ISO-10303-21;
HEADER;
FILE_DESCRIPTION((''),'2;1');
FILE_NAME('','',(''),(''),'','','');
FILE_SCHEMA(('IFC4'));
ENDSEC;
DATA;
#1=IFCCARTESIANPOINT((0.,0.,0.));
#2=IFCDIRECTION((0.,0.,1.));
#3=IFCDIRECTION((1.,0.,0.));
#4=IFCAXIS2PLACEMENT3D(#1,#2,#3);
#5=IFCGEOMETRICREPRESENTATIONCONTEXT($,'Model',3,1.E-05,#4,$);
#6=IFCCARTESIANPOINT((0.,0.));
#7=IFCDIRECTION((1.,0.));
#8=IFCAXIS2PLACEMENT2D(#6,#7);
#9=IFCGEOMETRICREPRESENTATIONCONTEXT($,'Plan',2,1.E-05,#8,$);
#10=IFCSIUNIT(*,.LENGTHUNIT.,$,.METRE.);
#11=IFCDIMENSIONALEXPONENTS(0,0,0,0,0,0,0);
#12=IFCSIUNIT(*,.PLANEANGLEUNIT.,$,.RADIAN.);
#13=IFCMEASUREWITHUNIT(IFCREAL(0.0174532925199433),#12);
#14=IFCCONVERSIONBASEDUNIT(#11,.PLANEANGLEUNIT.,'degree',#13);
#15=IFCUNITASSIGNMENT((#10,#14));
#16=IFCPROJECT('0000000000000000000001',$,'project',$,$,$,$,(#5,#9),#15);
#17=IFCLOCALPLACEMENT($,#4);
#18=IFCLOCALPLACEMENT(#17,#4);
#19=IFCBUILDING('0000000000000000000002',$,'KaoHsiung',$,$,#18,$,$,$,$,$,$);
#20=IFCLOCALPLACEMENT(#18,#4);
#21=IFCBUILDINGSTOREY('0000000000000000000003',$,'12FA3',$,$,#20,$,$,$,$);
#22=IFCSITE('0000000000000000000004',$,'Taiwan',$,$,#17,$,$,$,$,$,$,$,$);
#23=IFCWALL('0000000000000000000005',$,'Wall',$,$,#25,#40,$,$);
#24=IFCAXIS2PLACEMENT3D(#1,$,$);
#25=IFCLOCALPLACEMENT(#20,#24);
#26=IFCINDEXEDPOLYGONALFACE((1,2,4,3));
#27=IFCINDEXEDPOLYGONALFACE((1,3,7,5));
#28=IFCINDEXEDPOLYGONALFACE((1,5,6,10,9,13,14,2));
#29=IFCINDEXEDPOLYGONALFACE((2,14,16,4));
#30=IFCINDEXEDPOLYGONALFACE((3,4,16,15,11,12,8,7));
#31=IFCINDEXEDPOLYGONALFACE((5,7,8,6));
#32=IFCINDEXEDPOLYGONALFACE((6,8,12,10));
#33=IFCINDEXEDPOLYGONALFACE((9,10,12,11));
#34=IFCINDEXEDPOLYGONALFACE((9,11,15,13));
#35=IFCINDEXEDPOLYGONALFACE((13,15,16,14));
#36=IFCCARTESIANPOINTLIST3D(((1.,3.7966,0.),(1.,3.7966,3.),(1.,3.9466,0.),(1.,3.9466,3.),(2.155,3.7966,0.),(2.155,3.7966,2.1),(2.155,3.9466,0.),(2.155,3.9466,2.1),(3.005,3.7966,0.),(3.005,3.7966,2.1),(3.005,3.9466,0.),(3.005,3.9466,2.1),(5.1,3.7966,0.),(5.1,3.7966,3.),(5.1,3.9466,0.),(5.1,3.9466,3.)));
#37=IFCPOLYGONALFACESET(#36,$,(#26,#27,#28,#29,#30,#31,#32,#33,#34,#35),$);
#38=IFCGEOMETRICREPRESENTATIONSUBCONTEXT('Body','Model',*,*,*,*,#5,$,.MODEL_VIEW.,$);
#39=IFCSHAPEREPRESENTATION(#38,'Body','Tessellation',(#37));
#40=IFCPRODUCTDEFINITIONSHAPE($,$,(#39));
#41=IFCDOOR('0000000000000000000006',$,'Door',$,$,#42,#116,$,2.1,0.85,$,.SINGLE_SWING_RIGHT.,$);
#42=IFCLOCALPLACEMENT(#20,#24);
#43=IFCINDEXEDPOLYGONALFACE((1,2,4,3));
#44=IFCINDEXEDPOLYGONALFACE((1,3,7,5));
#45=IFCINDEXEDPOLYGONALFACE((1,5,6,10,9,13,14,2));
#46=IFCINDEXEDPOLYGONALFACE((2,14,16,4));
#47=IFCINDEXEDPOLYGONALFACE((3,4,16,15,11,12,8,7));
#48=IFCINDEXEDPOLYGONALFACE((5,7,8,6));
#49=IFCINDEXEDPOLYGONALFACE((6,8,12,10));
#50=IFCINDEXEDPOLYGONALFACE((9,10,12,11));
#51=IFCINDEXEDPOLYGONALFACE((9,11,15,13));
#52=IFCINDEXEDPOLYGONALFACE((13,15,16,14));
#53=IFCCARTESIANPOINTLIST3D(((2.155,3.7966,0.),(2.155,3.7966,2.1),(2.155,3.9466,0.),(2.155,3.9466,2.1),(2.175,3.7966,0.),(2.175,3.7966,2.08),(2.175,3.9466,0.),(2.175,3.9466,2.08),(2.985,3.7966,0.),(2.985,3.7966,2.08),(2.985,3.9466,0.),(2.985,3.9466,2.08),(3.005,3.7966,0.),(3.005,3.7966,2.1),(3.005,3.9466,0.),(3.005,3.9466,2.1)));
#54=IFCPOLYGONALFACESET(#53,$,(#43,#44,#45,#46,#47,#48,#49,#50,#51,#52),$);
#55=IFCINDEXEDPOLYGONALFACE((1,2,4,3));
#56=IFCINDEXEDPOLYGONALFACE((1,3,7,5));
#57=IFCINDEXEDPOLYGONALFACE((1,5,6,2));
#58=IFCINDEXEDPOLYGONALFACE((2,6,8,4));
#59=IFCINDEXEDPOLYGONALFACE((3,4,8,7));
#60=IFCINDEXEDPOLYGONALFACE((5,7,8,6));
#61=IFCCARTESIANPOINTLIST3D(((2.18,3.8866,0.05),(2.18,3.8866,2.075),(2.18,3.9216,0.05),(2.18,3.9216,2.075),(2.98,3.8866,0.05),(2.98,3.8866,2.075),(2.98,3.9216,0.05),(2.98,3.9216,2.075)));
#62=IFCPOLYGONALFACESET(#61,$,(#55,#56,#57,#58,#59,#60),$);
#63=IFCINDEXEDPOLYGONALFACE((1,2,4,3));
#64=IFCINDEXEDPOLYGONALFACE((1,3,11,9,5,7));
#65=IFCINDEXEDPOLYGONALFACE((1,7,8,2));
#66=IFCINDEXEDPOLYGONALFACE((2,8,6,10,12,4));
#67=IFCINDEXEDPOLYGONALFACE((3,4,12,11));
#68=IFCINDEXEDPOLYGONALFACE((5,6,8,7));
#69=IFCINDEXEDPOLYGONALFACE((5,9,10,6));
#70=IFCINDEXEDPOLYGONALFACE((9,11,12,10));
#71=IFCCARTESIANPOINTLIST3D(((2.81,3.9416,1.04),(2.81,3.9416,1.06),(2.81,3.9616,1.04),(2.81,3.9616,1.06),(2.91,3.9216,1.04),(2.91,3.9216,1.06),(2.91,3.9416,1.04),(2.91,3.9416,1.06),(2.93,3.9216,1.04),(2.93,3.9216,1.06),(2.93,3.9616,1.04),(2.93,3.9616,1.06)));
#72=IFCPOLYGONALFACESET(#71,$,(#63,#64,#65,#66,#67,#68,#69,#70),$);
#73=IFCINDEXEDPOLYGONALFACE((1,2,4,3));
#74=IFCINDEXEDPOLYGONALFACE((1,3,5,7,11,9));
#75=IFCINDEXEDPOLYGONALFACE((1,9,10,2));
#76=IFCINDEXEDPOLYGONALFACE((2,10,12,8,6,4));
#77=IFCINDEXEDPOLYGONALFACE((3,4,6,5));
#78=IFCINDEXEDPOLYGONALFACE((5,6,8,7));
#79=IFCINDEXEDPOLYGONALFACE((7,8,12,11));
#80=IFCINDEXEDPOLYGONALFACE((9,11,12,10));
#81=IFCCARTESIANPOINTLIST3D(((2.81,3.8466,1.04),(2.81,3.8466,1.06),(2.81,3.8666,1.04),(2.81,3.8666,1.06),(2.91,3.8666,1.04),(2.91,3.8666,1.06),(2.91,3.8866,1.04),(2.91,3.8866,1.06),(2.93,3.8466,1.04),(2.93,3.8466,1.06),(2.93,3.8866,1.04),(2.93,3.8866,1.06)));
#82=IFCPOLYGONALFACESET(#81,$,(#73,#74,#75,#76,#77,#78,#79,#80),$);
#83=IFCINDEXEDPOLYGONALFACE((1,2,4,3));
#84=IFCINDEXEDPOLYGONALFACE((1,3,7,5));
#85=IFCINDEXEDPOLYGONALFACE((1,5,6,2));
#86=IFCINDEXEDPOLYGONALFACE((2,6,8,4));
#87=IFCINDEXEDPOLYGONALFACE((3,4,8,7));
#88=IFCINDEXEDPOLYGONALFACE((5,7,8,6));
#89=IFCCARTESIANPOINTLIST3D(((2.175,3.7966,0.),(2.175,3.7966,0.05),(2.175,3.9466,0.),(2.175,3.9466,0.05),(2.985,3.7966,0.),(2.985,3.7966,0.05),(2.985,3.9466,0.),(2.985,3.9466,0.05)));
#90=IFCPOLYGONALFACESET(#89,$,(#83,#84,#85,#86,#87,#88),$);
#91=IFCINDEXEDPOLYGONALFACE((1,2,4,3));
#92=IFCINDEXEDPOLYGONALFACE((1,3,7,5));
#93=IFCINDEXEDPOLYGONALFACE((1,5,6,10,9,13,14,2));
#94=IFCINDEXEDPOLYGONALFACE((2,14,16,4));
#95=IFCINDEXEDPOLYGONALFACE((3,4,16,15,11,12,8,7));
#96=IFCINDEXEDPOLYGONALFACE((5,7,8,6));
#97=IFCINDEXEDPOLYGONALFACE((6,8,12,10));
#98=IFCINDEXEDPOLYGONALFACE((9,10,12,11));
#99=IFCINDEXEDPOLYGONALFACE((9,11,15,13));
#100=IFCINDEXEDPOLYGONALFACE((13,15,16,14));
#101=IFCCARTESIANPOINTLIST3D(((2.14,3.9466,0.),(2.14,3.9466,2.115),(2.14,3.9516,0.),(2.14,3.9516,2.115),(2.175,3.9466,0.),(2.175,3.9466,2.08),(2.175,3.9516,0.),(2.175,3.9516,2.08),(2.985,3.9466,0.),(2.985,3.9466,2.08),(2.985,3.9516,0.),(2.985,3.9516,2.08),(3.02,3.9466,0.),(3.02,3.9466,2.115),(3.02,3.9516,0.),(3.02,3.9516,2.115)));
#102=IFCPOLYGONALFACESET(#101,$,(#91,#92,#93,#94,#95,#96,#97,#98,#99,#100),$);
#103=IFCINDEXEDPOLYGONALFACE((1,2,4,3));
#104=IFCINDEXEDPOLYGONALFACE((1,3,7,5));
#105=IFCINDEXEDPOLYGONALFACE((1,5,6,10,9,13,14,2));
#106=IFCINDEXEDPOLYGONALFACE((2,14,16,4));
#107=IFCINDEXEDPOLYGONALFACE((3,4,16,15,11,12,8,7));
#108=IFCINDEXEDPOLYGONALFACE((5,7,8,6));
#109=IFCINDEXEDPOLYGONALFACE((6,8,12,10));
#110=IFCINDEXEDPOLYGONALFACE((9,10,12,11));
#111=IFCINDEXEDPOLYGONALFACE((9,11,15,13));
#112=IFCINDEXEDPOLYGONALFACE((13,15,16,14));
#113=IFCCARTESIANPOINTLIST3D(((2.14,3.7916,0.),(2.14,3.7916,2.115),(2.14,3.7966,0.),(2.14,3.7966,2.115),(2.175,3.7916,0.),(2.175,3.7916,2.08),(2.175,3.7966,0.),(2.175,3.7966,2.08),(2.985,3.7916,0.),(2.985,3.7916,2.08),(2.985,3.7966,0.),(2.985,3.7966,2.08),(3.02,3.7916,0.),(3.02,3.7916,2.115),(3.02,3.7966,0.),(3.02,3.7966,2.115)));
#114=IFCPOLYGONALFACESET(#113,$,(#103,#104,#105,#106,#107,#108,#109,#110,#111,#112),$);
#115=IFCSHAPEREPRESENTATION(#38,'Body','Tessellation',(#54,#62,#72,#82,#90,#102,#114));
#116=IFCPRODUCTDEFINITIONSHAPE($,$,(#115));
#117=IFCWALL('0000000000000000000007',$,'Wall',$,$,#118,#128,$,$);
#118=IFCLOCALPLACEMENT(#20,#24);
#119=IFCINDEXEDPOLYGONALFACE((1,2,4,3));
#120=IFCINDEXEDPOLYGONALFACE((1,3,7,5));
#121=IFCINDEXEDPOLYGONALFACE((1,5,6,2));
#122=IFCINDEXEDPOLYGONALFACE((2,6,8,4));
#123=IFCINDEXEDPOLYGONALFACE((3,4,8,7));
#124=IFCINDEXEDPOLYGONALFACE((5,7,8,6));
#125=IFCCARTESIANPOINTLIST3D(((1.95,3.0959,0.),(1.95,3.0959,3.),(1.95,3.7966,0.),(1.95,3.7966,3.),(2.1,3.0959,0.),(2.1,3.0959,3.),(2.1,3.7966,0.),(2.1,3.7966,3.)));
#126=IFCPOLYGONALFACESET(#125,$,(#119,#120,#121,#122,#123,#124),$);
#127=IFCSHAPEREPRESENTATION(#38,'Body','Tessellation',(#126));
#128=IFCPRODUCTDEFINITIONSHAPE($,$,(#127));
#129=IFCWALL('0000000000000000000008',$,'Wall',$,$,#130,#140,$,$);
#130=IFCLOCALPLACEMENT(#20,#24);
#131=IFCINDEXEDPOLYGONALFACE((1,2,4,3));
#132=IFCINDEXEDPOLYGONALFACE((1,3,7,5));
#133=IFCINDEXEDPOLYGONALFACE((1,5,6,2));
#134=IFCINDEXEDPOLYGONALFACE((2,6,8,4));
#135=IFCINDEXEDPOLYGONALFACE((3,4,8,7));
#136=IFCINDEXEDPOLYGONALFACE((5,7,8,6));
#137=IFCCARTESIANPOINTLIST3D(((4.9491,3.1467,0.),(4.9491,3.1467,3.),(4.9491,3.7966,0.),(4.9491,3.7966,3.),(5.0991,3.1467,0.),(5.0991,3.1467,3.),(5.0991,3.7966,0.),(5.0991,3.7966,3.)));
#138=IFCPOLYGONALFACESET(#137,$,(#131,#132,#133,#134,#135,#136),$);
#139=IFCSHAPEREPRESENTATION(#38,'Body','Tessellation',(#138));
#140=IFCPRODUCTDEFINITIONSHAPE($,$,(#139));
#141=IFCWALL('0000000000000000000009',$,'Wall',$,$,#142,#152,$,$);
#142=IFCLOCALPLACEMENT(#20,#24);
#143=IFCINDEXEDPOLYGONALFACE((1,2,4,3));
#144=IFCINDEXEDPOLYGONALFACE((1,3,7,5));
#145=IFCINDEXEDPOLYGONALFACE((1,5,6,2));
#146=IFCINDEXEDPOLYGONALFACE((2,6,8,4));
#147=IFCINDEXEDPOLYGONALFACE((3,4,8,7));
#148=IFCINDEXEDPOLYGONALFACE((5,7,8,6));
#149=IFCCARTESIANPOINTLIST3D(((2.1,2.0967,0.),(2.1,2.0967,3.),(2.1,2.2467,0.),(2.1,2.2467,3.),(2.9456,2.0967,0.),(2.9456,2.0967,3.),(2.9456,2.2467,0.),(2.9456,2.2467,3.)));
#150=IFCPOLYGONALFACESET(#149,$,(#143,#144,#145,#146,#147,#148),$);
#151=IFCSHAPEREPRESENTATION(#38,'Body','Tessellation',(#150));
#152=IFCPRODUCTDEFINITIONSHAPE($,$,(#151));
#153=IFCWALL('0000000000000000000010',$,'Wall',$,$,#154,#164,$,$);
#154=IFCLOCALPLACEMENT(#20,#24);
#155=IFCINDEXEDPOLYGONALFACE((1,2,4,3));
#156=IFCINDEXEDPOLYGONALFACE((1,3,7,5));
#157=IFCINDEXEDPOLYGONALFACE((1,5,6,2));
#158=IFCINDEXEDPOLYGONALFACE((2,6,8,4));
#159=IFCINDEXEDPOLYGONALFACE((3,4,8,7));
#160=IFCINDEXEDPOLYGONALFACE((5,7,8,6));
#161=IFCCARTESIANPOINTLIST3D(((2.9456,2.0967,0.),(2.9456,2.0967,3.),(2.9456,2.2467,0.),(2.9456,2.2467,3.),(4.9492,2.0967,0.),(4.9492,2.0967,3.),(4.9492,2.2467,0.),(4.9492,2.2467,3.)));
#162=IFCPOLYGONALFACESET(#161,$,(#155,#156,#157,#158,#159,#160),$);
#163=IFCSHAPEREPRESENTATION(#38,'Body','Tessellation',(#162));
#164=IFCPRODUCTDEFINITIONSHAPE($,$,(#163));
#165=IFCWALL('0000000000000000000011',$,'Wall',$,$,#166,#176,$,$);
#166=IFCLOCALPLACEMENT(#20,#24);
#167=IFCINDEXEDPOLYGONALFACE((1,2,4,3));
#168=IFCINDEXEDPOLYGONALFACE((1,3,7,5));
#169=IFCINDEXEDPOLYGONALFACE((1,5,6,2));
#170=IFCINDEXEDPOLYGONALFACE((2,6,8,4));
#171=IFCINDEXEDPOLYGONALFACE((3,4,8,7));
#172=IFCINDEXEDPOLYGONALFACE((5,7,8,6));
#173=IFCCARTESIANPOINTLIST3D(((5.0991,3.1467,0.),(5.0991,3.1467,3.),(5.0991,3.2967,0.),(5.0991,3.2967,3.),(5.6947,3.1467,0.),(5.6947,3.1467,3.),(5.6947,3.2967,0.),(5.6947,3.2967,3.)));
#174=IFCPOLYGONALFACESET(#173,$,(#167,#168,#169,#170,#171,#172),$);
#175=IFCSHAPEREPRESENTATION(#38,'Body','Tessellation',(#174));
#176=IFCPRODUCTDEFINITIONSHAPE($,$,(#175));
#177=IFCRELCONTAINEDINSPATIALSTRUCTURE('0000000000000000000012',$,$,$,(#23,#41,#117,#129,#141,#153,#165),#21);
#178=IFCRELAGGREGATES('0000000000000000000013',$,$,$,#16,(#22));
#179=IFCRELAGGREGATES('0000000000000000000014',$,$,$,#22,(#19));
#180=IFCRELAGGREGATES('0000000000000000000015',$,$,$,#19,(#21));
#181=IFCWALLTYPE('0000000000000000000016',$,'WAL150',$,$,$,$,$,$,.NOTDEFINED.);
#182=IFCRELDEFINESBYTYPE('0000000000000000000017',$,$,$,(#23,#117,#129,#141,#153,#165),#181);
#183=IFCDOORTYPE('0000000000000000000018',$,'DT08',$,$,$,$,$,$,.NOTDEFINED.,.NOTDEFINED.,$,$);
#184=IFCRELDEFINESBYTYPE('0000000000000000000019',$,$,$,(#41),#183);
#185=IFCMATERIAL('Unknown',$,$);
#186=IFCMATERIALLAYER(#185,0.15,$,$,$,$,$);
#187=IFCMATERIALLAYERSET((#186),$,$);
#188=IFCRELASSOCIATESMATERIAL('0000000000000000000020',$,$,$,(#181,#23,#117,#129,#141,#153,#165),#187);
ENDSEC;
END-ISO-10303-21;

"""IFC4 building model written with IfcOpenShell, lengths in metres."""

from ifc_helpers import new_model, entity, si_unit, converted_unit, frame, origin_with_axes, origin_2d_with_axis, place, context, subcontext, project, spatial, line, indexed_curve, outline, extrude, shape, source, transform, mapped, material, layer, layer_set, layer_usage, type_object, type_shapes, element, fill, save


model = new_model("IFC4")

# Units and contexts
model_context = context("Model", 3, precision=1e-05, world=origin_with_axes())
plan_context = context("Plan", 2, precision=1e-05, world=origin_2d_with_axis())
body_context_1 = subcontext(model_context, "Body", "Model", "MODEL_VIEW")
body_context_2 = subcontext(plan_context, "Body", "Plan", "PLAN_VIEW")
ifc_project = project(units=[si_unit("LENGTHUNIT", "METRE"), converted_unit("PLANEANGLEUNIT", "degree", entity("IfcReal", 0.0174532925199433), si_unit("PLANEANGLEUNIT", "RADIAN"), dimensions=[0, 0, 0, 0, 0, 0, 0])], contexts=[model_context, plan_context])

# Site, building, storey
site_placement = place(None, origin_with_axes())
site = spatial("IfcSite", under=ifc_project, at=site_placement, Name="Taiwan")
building_placement = place(site_placement, origin_with_axes())
building = spatial("IfcBuilding", under=site, at=building_placement, Name="KaoHsiung")
storey_placement = place(building_placement, origin_with_axes())
storey = spatial("IfcBuildingStorey", under=building, at=storey_placement, Name="12FA3")

# Shared definitions
ifc_material = material(Name="Unknown")

# Wall, opening, door
ifc_layer_1 = layer(ifc_material, 0.15)
ifc_layer_set_1 = layer_set([ifc_layer_1])
ifc_layer_usage_1 = layer_usage(ifc_layer_set_1, "AXIS2", "POSITIVE", 0.0)
wall_type_1 = type_object("IfcWallType", Name="WAL150", PredefinedType="NOTDEFINED", material=ifc_layer_set_1)
wall_1_placement = place(storey_placement, frame((1.0, 3.7966, 0.0), z_axis=(0.0, 0.0, 1.0), x_axis=(1.0, 0.0, 0.0)))
wall_1 = element("IfcWall", 1, at=wall_1_placement, inside=storey, type_object=wall_type_1, material=ifc_layer_usage_1, Name="Wall", context=body_context_1, shape_type="SweptSolid", body=[
    extrude(outline(indexed_curve([(0.0, 0.0), (0.0, 0.15), (4.1, 0.15), (4.1, 0.0)], segments=[line(1, 2, 3, 4, 1)])), origin_with_axes(), (0.0, 0.0, 1.0), 3.0),
])
shared_shape_1 = source(origin_with_axes(), body_context_1, "Body", "SweptSolid", [
    extrude(outline(indexed_curve([(0.0, 0.0), (0.85, 0.0), (0.85, 2.1), (0.0, 2.1)], segments=[line(1, 2, 3, 4, 1)])), frame((0.0, -0.6, 0.0), z_axis=(0.0, -1.0, 0.0), x_axis=(1.0, 0.0, 0.0)), (0.0, 0.0, -1.0), 1.2),
])
opening_1_placement = place(wall_1_placement, frame((2.005, 0.15, 0.0), z_axis=(0.0, 0.0, 1.0), x_axis=(-1.0, 0.0, 0.0)))
opening_1 = element("IfcOpeningElement", 2, at=opening_1_placement, cuts=wall_1, PredefinedType="OPENING", context=body_context_1, shape_type="MappedRepresentation", body=[
    mapped(shared_shape_1, transform((0.0, 0.0, 0.0), x_axis=(1.0, 0.0, 0.0), y_axis=(0.0, 1.0, 0.0), z_axis=(0.0, 0.0, 1.0), scale=1.0)),
])
door_type_1 = type_object("IfcDoorType", Name="DT08", OperationType="NOTDEFINED", PredefinedType="NOTDEFINED")
shared_shape_2 = source(origin_with_axes(), body_context_1, "Body", "SweptSolid", [
    extrude(outline(indexed_curve([(0.0, 0.0), (0.0, 2.1), (0.85, 2.1), (0.85, 0.0), (0.83, 0.0), (0.83, 2.08), (0.02, 2.08), (0.02, 0.0)], segments=[line(1, 2, 3, 4, 5, 6, 7, 8, 1)])), frame((0.0, 0.0, 0.0), z_axis=(0.0, -1.0, 0.0), x_axis=(1.0, 0.0, 0.0)), (0.0, 0.0, -1.0), 0.15),
    extrude(outline(indexed_curve([(0.0, 0.0), (0.8, 0.0), (0.8, 0.035), (0.0, 0.035)], segments=[line(1, 2, 3, 4, 1)])), frame((0.025, 0.025, 0.05), z_axis=(0.0, 0.0, 1.0), x_axis=(1.0, 0.0, 0.0)), (0.0, 0.0, 1.0), 2.025),
    extrude(outline(indexed_curve([(0.0, 0.0), (0.0, -0.04), (0.12, -0.04), (0.12, -0.02), (0.02, -0.02), (0.02, 0.0)], segments=[line(1, 2, 3, 4, 5, 6, 1)])), frame((0.075, 0.025, 1.04), z_axis=(0.0, 0.0, 1.0), x_axis=(1.0, 0.0, 0.0)), (0.0, 0.0, 1.0), 0.02),
    extrude(outline(indexed_curve([(0.0, 0.0), (0.0, 0.04), (0.12, 0.04), (0.12, 0.02), (0.02, 0.02), (0.02, 0.0)], segments=[line(1, 2, 3, 4, 5, 6, 1)])), frame((0.075, 0.06, 1.04), z_axis=(0.0, 0.0, 1.0), x_axis=(1.0, 0.0, 0.0)), (0.0, 0.0, 1.0), 0.02),
    extrude(outline(indexed_curve([(0.0, 0.0), (0.81, 0.0), (0.81, 0.15), (0.0, 0.15)], segments=[line(1, 2, 3, 4, 1)])), frame((0.02, 0.0, 0.0), z_axis=(0.0, 0.0, 1.0), x_axis=(1.0, 0.0, 0.0)), (0.0, 0.0, 1.0), 0.05),
    extrude(outline(indexed_curve([(0.0, 0.0), (0.0, 2.115), (0.88, 2.115), (0.88, 0.0), (0.845, 0.0), (0.845, 2.08), (0.035, 2.08), (0.035, 0.0)], segments=[line(1, 2, 3, 4, 5, 6, 7, 8, 1)])), frame((-0.015, -0.005, 0.0), z_axis=(0.0, -1.0, 0.0), x_axis=(1.0, 0.0, 0.0)), (0.0, 0.0, -1.0), 0.005),
    extrude(outline(indexed_curve([(0.0, 0.0), (0.0, 2.115), (0.88, 2.115), (0.88, 0.0), (0.845, 0.0), (0.845, 2.08), (0.035, 2.08), (0.035, 0.0)], segments=[line(1, 2, 3, 4, 5, 6, 7, 8, 1)])), frame((-0.015, 0.15, 0.0), z_axis=(0.0, -1.0, 0.0), x_axis=(1.0, 0.0, 0.0)), (0.0, 0.0, -1.0), 0.005),
])
shared_shape_3 = source(origin_with_axes(), body_context_2, "Body", "Curve2D", [
    entity("IfcIndexedPolyCurve", entity("IfcCartesianPointList2D", [[0.0, 0.0], [0.02, 0.0], [0.02, 0.15], [0.0, 0.15]]), [entity("IfcLineIndex", [1, 2, 3, 4, 1])]),
    entity("IfcIndexedPolyCurve", entity("IfcCartesianPointList2D", [[0.85, 0.0], [0.83, 0.0], [0.83, 0.15], [0.85, 0.15]]), [entity("IfcLineIndex", [1, 2, 3, 4, 1])]),
    entity("IfcTrimmedCurve", entity("IfcEllipse", entity("IfcAxis2Placement2D", entity("IfcCartesianPoint", [0.79, 0.15]), entity("IfcDirection", [1.0, 0.0])), 0.765, 0.8), [entity("IfcCartesianPoint", [0.79, 0.95])], [entity("IfcCartesianPoint", [0.025, 0.15])], True, "CARTESIAN"),
    entity("IfcIndexedPolyCurve", entity("IfcCartesianPointList2D", [[0.825, 0.15], [0.79, 0.15], [0.79, 0.95], [0.825, 0.95]]), [entity("IfcLineIndex", [1, 2, 3, 4, 1])]),
])
type_shapes(door_type_1, [shared_shape_2, shared_shape_3])
door_1_placement = place(opening_1_placement, origin_with_axes())
door_1 = element("IfcDoor", 3, at=door_1_placement, inside=storey, type_object=door_type_1, Name="Door", OperationType="SINGLE_SWING_RIGHT", OverallHeight=2.1, OverallWidth=0.85, shapes=[
    shape(body_context_1, "Body", "MappedRepresentation", [mapped(shared_shape_2, transform((0.0, 0.0, 0.0), x_axis=(1.0, 0.0, 0.0), y_axis=(0.0, 1.0, 0.0), z_axis=(0.0, 0.0, 1.0), scale=1.0))]),
    shape(body_context_2, "Body", "MappedRepresentation", [mapped(shared_shape_3, transform((0.0, 0.0, 0.0), x_axis=(1.0, 0.0, 0.0), y_axis=(0.0, 1.0, 0.0), z_axis=(0.0, 0.0, 1.0), scale=1.0))]),
])
fill(opening_1, door_1)

# Walls
ifc_layer_usage_2 = layer_usage(ifc_layer_set_1, "AXIS2", "POSITIVE", 0.0)
wall_2_placement = place(storey_placement, frame((1.95, 3.7966, 0.0), z_axis=(0.0, 0.0, 1.0), x_axis=(0.0, -1.0, 0.0)))
element("IfcWall", 4, at=wall_2_placement, inside=storey, type_object=wall_type_1, material=ifc_layer_usage_2, Name="Wall", context=body_context_1, shape_type="SweptSolid", body=[
    extrude(outline(indexed_curve([(0.0, 0.0), (0.0, 0.15), (0.7007, 0.15), (0.7007, 0.0)], segments=[line(1, 2, 3, 4, 1)])), origin_with_axes(), (0.0, 0.0, 1.0), 3.0),
])
ifc_layer_usage_3 = layer_usage(ifc_layer_set_1, "AXIS2", "POSITIVE", 0.0)
wall_3_placement = place(storey_placement, frame((4.9491, 3.7966, 0.0), z_axis=(0.0, 0.0, 1.0), x_axis=(0.0, -1.0, 0.0)))
element("IfcWall", 5, at=wall_3_placement, inside=storey, type_object=wall_type_1, material=ifc_layer_usage_3, Name="Wall", context=body_context_1, shape_type="SweptSolid", body=[
    extrude(outline(indexed_curve([(0.0, 0.0), (0.0, 0.15), (0.6499, 0.15), (0.6499, 0.0)], segments=[line(1, 2, 3, 4, 1)])), origin_with_axes(), (0.0, 0.0, 1.0), 3.0),
])
ifc_layer_usage_4 = layer_usage(ifc_layer_set_1, "AXIS2", "POSITIVE", 0.0)
wall_4_placement = place(storey_placement, frame((2.1, 2.0967, 0.0), z_axis=(0.0, 0.0, 1.0), x_axis=(1.0, 0.0, 0.0)))
element("IfcWall", 6, at=wall_4_placement, inside=storey, type_object=wall_type_1, material=ifc_layer_usage_4, Name="Wall", context=body_context_1, shape_type="SweptSolid", body=[
    extrude(outline(indexed_curve([(0.0, 0.0), (0.0, 0.15), (0.8456, 0.15), (0.8456, 0.0)], segments=[line(1, 2, 3, 4, 1)])), origin_with_axes(), (0.0, 0.0, 1.0), 3.0),
])
ifc_layer_usage_5 = layer_usage(ifc_layer_set_1, "AXIS2", "POSITIVE", 0.0)
wall_5_placement = place(storey_placement, frame((2.9456, 2.0967, 0.0), z_axis=(0.0, 0.0, 1.0), x_axis=(1.0, 0.0, 0.0)))
element("IfcWall", 7, at=wall_5_placement, inside=storey, type_object=wall_type_1, material=ifc_layer_usage_5, Name="Wall", context=body_context_1, shape_type="SweptSolid", body=[
    extrude(outline(indexed_curve([(0.0, 0.0), (0.0, 0.15), (2.0037, 0.15), (2.0037, 0.0)], segments=[line(1, 2, 3, 4, 1)])), origin_with_axes(), (0.0, 0.0, 1.0), 3.0),
])
ifc_layer_usage_6 = layer_usage(ifc_layer_set_1, "AXIS2", "POSITIVE", 0.0)
wall_6_placement = place(storey_placement, frame((5.0991, 3.1467, 0.0), z_axis=(0.0, 0.0, 1.0), x_axis=(1.0, 0.0, 0.0)))
element("IfcWall", 8, at=wall_6_placement, inside=storey, type_object=wall_type_1, material=ifc_layer_usage_6, Name="Wall", context=body_context_1, shape_type="SweptSolid", body=[
    extrude(outline(indexed_curve([(0.0, 0.0), (0.0, 0.15), (0.5956, 0.15), (0.5956, 0.0)], segments=[line(1, 2, 3, 4, 1)])), origin_with_axes(), (0.0, 0.0, 1.0), 3.0),
])

save(model, "model.ifc")
